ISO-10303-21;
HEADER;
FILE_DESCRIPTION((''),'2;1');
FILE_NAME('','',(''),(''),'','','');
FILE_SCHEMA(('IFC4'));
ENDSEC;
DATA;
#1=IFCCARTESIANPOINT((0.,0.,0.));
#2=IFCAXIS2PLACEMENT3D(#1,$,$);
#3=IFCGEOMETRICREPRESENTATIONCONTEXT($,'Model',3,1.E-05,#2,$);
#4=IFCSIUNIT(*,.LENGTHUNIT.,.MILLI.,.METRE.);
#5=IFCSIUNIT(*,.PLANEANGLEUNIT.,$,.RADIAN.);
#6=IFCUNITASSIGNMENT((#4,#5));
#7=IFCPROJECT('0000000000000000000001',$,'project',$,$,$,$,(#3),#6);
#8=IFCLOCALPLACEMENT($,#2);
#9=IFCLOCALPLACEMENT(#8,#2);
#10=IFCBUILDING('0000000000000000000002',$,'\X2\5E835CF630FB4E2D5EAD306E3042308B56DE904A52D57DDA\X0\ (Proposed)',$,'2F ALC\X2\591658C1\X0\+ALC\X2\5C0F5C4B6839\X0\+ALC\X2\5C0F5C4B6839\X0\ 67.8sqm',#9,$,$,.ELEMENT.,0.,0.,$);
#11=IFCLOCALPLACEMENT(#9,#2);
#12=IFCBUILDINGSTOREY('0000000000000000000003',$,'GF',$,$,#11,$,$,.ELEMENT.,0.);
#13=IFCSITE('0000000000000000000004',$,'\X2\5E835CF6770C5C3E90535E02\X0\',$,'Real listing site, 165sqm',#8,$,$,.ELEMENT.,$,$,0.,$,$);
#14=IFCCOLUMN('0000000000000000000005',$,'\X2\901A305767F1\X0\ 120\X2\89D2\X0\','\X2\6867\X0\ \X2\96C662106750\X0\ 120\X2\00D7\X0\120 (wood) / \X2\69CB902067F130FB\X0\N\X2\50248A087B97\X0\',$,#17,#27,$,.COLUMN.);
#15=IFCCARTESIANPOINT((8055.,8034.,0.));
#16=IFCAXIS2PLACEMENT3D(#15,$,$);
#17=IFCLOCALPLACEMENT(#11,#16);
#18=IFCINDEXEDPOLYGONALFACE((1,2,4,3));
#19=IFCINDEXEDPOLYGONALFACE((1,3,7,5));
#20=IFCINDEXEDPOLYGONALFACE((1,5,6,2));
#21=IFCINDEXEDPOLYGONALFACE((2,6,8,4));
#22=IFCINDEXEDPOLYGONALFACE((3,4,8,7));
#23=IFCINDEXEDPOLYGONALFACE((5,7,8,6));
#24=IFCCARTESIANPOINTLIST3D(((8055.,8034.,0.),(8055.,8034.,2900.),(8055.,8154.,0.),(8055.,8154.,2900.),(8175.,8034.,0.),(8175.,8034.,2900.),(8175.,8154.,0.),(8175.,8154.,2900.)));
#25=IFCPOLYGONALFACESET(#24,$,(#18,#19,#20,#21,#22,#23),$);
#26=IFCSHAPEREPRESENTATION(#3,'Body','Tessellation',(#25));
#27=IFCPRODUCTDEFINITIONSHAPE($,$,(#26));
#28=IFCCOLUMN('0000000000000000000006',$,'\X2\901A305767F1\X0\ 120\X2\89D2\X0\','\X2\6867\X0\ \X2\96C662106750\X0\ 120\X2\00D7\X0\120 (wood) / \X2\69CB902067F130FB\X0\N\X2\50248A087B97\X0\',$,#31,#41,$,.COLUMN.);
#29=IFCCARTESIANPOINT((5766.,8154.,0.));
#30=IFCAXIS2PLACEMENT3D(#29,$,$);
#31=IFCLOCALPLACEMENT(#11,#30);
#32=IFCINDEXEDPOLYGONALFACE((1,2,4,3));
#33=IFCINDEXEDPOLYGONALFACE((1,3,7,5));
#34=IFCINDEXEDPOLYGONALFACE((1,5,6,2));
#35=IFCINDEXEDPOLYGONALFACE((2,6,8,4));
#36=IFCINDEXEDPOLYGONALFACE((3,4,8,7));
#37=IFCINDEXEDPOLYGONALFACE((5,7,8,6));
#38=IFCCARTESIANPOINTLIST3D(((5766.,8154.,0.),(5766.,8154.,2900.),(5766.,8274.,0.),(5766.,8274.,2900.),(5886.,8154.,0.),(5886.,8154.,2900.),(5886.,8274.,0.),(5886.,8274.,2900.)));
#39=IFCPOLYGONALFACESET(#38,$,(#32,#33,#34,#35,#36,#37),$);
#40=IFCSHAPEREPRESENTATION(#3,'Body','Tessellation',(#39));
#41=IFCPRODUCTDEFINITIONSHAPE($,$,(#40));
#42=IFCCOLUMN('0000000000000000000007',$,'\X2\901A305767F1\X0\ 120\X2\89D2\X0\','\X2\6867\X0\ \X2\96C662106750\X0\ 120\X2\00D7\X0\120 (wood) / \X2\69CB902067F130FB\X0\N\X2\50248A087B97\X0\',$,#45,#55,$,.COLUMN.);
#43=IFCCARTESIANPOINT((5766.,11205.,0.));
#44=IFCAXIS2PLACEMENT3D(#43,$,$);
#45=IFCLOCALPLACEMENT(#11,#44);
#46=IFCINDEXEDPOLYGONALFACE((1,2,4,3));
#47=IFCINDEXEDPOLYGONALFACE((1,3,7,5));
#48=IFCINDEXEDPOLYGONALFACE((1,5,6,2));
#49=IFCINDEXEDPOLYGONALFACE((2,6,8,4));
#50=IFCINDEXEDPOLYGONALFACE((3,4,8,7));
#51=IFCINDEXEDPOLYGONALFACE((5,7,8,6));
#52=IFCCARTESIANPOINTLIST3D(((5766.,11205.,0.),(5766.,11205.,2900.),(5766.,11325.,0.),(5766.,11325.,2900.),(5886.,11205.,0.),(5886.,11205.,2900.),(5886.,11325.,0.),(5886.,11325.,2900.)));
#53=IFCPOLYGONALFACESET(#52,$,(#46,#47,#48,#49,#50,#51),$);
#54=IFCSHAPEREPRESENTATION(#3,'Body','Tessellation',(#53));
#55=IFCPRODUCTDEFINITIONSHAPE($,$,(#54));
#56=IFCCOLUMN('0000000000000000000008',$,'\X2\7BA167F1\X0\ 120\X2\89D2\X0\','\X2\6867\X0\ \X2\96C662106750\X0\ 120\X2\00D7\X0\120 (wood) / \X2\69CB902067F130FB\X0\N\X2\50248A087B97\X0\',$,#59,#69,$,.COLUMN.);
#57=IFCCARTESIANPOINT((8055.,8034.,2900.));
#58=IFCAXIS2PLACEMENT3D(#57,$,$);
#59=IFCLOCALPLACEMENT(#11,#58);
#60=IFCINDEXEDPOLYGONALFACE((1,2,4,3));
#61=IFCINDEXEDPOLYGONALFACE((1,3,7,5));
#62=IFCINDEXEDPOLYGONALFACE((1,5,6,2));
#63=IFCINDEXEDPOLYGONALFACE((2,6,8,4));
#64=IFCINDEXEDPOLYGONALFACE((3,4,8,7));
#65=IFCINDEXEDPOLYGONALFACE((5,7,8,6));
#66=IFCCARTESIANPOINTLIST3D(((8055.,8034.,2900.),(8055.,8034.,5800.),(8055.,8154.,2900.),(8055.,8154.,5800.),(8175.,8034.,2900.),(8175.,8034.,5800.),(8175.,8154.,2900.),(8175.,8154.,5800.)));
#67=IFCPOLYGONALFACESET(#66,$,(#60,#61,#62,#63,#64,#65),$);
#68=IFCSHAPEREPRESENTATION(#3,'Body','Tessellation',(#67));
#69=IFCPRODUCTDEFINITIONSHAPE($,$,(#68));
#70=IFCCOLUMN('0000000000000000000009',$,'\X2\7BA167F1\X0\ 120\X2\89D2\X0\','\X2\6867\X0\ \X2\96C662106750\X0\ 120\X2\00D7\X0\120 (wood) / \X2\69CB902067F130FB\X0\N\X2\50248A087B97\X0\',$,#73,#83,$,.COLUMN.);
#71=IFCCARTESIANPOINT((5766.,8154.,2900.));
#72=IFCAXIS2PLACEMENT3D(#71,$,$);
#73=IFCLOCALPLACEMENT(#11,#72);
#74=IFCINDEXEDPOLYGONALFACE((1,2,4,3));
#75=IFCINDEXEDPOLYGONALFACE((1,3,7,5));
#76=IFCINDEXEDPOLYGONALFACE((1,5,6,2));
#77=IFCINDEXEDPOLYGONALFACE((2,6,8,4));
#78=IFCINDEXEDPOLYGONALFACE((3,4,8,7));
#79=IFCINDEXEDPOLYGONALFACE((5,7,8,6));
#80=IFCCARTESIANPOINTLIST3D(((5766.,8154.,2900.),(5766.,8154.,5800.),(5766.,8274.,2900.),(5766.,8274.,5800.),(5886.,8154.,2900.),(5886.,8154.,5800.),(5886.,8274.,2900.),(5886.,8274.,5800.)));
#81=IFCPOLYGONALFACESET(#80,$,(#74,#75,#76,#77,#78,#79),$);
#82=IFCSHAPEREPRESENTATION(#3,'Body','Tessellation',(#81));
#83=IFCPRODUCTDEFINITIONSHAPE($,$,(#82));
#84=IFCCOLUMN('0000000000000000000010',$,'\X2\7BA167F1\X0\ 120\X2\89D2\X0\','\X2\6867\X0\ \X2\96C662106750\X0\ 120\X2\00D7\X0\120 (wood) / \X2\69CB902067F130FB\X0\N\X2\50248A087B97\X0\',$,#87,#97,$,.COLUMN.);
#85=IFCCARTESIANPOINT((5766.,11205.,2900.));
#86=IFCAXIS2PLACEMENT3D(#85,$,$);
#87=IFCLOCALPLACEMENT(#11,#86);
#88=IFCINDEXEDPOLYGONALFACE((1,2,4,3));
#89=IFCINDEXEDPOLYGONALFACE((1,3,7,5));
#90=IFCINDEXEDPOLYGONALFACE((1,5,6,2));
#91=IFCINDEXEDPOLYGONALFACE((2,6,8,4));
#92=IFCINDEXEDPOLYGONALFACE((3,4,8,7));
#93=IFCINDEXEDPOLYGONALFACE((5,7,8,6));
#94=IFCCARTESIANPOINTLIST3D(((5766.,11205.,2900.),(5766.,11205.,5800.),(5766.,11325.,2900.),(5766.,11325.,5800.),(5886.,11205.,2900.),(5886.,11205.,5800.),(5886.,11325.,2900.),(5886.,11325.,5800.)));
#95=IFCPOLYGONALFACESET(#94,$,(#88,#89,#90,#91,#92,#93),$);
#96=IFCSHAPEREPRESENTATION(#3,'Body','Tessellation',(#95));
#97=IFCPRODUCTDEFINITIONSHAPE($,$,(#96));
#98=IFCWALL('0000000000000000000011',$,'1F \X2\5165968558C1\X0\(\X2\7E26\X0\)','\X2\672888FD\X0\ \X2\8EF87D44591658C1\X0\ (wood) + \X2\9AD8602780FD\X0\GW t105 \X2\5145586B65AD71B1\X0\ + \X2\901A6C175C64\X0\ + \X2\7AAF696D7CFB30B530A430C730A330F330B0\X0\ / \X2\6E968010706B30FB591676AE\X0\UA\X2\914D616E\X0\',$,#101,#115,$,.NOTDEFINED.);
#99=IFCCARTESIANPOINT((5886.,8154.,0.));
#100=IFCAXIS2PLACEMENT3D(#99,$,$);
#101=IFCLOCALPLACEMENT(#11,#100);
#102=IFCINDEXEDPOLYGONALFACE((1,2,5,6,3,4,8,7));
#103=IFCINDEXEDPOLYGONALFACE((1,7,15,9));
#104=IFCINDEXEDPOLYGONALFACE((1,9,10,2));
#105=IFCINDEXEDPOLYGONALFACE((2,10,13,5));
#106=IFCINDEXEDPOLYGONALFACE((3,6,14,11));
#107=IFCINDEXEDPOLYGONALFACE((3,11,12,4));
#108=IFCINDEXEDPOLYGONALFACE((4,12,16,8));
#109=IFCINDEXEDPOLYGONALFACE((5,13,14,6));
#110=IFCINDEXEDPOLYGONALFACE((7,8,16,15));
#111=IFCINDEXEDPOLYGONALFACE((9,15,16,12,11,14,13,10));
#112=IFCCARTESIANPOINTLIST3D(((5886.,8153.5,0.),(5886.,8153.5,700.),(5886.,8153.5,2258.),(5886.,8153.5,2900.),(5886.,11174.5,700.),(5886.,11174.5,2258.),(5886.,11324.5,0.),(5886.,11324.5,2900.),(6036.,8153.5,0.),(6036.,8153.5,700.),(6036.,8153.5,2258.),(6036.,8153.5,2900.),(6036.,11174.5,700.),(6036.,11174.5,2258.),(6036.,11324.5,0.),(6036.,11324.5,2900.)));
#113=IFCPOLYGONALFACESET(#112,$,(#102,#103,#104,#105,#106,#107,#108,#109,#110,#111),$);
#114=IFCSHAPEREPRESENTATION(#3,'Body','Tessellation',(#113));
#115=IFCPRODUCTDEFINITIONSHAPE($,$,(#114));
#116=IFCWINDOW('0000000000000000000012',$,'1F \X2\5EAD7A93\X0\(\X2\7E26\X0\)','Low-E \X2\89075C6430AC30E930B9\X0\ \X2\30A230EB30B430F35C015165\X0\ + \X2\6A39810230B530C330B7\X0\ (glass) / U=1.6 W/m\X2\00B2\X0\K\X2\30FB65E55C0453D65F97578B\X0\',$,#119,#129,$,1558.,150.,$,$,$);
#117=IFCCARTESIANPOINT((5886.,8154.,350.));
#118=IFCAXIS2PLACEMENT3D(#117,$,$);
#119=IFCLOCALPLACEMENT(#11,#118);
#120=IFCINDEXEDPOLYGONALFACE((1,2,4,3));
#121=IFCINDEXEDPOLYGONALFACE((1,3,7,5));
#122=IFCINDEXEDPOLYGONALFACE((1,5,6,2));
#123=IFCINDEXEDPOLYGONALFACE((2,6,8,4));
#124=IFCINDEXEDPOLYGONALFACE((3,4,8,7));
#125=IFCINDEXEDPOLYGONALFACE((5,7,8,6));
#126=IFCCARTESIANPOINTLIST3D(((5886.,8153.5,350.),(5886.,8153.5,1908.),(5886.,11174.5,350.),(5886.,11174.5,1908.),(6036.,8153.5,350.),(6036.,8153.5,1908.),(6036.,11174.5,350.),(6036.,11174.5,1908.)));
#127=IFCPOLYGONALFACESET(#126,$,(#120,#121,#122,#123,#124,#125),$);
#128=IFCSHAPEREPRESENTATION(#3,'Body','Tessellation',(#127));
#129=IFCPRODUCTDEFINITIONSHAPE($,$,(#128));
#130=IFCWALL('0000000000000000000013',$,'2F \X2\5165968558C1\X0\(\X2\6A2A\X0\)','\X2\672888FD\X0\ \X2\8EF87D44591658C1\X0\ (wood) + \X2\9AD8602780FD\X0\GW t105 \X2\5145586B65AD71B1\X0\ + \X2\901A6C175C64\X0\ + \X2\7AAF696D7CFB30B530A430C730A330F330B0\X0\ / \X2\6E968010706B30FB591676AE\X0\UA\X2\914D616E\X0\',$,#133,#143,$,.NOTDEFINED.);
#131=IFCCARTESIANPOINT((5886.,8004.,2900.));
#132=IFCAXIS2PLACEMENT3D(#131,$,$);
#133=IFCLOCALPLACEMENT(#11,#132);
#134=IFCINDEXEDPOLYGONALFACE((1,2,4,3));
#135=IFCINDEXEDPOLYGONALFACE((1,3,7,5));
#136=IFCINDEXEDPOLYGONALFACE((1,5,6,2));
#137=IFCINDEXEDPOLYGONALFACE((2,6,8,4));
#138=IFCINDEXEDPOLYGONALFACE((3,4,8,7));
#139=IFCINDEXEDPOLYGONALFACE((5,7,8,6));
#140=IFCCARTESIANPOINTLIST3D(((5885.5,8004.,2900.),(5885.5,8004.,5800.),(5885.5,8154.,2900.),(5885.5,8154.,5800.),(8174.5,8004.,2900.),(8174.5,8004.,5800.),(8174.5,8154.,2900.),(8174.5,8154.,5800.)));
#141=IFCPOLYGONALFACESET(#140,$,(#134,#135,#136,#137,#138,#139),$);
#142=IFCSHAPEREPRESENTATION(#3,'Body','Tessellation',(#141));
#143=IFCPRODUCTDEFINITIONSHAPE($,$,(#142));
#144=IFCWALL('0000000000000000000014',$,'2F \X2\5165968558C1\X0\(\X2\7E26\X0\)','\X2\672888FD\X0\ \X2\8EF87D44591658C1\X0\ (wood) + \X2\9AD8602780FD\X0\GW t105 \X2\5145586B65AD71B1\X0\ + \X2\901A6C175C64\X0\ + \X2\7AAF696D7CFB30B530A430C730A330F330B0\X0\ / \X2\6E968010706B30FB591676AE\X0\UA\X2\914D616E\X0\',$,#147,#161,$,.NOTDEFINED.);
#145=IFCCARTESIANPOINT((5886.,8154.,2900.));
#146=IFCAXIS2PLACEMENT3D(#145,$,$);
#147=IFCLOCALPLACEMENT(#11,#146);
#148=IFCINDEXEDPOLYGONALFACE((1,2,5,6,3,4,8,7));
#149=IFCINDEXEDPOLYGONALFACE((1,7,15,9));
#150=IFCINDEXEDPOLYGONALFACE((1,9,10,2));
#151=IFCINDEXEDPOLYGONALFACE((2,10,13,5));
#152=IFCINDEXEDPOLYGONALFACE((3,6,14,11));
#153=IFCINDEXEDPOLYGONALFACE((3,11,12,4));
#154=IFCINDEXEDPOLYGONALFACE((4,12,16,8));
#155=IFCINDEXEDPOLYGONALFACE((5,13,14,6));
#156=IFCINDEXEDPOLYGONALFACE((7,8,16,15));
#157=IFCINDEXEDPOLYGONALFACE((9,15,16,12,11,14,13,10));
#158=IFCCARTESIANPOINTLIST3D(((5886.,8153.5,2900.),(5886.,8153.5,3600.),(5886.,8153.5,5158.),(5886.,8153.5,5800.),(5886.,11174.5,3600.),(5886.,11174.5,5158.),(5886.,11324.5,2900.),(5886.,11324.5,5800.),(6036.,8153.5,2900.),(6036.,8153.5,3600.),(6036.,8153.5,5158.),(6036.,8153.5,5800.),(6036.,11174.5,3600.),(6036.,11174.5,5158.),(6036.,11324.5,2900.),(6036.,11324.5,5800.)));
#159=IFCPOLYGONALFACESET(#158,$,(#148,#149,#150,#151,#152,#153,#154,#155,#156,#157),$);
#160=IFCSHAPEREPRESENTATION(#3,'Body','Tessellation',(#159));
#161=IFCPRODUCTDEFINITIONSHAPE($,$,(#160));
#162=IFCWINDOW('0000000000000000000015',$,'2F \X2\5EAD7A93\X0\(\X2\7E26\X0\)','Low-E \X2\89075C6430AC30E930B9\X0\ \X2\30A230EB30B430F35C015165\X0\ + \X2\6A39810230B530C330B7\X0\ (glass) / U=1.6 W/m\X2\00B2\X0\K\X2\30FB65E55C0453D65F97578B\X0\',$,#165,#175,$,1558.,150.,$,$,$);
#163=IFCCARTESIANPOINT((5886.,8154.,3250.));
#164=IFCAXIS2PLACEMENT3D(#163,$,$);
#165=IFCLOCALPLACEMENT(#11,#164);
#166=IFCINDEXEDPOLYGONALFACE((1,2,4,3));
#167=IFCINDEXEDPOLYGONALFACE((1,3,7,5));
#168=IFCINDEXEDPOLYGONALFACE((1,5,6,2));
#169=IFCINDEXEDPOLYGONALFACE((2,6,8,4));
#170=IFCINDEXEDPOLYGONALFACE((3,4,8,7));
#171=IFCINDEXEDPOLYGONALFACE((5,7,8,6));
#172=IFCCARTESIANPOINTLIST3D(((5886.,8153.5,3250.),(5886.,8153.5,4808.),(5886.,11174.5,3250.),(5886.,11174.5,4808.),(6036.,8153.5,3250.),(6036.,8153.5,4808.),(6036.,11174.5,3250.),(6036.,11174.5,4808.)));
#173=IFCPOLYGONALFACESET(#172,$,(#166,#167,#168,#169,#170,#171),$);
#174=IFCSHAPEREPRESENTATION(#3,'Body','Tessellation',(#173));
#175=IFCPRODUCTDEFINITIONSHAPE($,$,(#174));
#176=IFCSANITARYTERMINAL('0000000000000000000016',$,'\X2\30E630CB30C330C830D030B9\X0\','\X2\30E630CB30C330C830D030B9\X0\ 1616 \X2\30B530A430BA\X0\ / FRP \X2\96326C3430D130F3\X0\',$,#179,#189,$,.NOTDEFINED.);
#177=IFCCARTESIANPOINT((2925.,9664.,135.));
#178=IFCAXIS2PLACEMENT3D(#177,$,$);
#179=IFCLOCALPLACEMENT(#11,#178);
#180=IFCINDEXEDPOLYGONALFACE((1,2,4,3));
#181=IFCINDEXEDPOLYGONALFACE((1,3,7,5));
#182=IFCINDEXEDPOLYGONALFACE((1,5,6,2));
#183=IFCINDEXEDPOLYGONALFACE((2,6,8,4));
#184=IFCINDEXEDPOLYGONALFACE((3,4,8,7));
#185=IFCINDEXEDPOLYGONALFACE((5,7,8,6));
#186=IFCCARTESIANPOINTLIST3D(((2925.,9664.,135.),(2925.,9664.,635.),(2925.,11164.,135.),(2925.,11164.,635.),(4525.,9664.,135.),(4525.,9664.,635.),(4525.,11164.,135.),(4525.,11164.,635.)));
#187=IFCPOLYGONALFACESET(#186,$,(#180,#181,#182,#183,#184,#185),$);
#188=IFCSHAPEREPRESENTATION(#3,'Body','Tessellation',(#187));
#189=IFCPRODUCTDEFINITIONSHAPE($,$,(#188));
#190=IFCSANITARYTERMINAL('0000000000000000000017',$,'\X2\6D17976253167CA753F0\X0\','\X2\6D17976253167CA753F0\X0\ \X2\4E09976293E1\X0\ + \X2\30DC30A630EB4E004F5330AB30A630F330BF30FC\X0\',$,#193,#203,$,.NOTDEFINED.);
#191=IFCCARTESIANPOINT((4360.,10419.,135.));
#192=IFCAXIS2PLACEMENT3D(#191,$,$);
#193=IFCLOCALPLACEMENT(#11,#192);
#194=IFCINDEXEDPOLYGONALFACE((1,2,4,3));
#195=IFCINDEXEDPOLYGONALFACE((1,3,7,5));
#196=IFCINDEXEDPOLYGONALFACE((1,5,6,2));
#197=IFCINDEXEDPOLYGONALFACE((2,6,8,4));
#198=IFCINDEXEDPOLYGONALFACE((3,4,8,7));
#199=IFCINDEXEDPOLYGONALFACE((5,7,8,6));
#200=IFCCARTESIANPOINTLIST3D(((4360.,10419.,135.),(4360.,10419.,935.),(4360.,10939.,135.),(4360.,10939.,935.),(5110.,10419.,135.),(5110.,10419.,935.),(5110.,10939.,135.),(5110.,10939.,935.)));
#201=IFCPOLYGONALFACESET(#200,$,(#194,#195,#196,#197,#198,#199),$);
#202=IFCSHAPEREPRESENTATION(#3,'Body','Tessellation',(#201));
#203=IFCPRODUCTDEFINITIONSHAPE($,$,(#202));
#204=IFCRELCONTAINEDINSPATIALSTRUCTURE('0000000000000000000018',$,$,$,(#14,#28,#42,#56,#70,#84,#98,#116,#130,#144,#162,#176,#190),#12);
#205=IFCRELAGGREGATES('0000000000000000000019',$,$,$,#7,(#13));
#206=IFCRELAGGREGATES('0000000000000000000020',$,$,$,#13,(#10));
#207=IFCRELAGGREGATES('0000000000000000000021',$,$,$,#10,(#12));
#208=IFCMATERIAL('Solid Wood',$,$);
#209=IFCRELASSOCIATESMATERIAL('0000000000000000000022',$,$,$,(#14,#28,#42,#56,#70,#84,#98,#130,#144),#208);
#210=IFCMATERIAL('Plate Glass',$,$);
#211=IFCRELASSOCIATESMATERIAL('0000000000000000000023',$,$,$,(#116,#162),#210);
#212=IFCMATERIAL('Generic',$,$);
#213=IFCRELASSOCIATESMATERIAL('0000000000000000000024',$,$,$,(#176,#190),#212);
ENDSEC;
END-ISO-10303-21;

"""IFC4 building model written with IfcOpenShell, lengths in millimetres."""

from ifc_helpers import new_model, si_unit, frame, frame_2d, origin, place, context, project, spatial, rectangle, extrude, material, element, fill, save


model = new_model("IFC4")

# Units and contexts
model_context = context("Model", 3, precision=1e-05, world=origin())
ifc_project = project(units=[si_unit("LENGTHUNIT", "METRE", prefix="MILLI"), si_unit("PLANEANGLEUNIT", "RADIAN")], contexts=[model_context])

# Site, building, storey
site_placement = place(None, origin())
site = spatial("IfcSite", under=ifc_project, at=site_placement, Name="広島県尾道市", ObjectType="Real listing site, 165sqm", CompositionType="ELEMENT", RefElevation=0.0)
building_placement = place(site_placement, origin())
building = spatial("IfcBuilding", under=site, at=building_placement, Name="広島・中庭のある回遊動線 (Proposed)", ObjectType="2F ALC外壁+ALC小屋根+ALC小屋根 67.8sqm", CompositionType="ELEMENT", ElevationOfRefHeight=0.0, ElevationOfTerrain=0.0)
storey_placement = place(building_placement, origin())
storey = spatial("IfcBuildingStorey", under=building, at=storey_placement, Name="GF", CompositionType="ELEMENT", Elevation=0.0)

# Columns
ifc_material_1 = material(Name="Solid Wood")
column_1_placement = place(storey_placement, frame((8055.0, 8034.0, 0.0)))
element("IfcColumn", 1, at=column_1_placement, inside=storey, material=ifc_material_1, Name="通し柱 120角", Description="桧 集成材 120×120 (wood) / 構造柱・N値計算", PredefinedType="COLUMN", context=model_context, shape_type="SweptSolid", body=[
    extrude(rectangle(XDim=120.0, YDim=120.0, at=frame_2d((60.0, 60.0))), frame((8055.0, 8034.0, 0.0)), (0.0, 0.0, 1.0), 2900.0),
])
column_2_placement = place(storey_placement, frame((5766.0, 8154.0, 0.0)))
element("IfcColumn", 2, at=column_2_placement, inside=storey, material=ifc_material_1, Name="通し柱 120角", Description="桧 集成材 120×120 (wood) / 構造柱・N値計算", PredefinedType="COLUMN", context=model_context, shape_type="SweptSolid", body=[
    extrude(rectangle(XDim=120.0, YDim=120.0, at=frame_2d((60.0, 60.0))), frame((5766.0, 8154.0, 0.0)), (0.0, 0.0, 1.0), 2900.0),
])
column_3_placement = place(storey_placement, frame((5766.0, 11205.0, 0.0)))
element("IfcColumn", 3, at=column_3_placement, inside=storey, material=ifc_material_1, Name="通し柱 120角", Description="桧 集成材 120×120 (wood) / 構造柱・N値計算", PredefinedType="COLUMN", context=model_context, shape_type="SweptSolid", body=[
    extrude(rectangle(XDim=120.0, YDim=120.0, at=frame_2d((60.0, 60.0))), frame((5766.0, 11205.0, 0.0)), (0.0, 0.0, 1.0), 2900.0),
])
column_4_placement = place(storey_placement, frame((8055.0, 8034.0, 2900.0)))
element("IfcColumn", 4, at=column_4_placement, inside=storey, material=ifc_material_1, Name="管柱 120角", Description="桧 集成材 120×120 (wood) / 構造柱・N値計算", PredefinedType="COLUMN", context=model_context, shape_type="SweptSolid", body=[
    extrude(rectangle(XDim=120.0, YDim=120.0, at=frame_2d((60.0, 60.0))), frame((8055.0, 8034.0, 2900.0)), (0.0, 0.0, 1.0), 2900.0),
])
column_5_placement = place(storey_placement, frame((5766.0, 8154.0, 2900.0)))
element("IfcColumn", 5, at=column_5_placement, inside=storey, material=ifc_material_1, Name="管柱 120角", Description="桧 集成材 120×120 (wood) / 構造柱・N値計算", PredefinedType="COLUMN", context=model_context, shape_type="SweptSolid", body=[
    extrude(rectangle(XDim=120.0, YDim=120.0, at=frame_2d((60.0, 60.0))), frame((5766.0, 8154.0, 2900.0)), (0.0, 0.0, 1.0), 2900.0),
])
column_6_placement = place(storey_placement, frame((5766.0, 11205.0, 2900.0)))
element("IfcColumn", 6, at=column_6_placement, inside=storey, material=ifc_material_1, Name="管柱 120角", Description="桧 集成材 120×120 (wood) / 構造柱・N値計算", PredefinedType="COLUMN", context=model_context, shape_type="SweptSolid", body=[
    extrude(rectangle(XDim=120.0, YDim=120.0, at=frame_2d((60.0, 60.0))), frame((5766.0, 11205.0, 2900.0)), (0.0, 0.0, 1.0), 2900.0),
])

# Wall, opening, window
wall_1_placement = place(storey_placement, frame((5886.0, 8154.0, 0.0)))
wall_1 = element("IfcWall", 7, at=wall_1_placement, inside=storey, material=ifc_material_1, Name="1F 入隅壁(縦)", Description="木製 軸組外壁 (wood) + 高性能GW t105 充填断熱 + 通気層 + 窯業系サイディング / 準耐火・外皮UA配慮", PredefinedType="NOTDEFINED", context=model_context, shape_type="SweptSolid", body=[
    extrude(rectangle(XDim=150.0, YDim=3171.0, at=frame_2d((75.0, 1585.0))), frame((5886.0, 8154.0, 0.0)), (0.0, 0.0, 1.0), 2900.0),
])
opening_1_placement = place(storey_placement, frame((5886.0, 8154.0, 350.0)))
opening_1 = element("IfcOpeningElement", 8, at=opening_1_placement, cuts=wall_1, PredefinedType="NOTDEFINED", context=model_context, shape_type="SweptSolid", body=[
    extrude(rectangle(XDim=150.0, YDim=3021.0, at=frame_2d((75.0, 1510.0))), frame((5886.0, 8154.0, 350.0)), (0.0, 0.0, 1.0), 1558.0),
])
ifc_material_2 = material(Name="Plate Glass")
window_1_placement = place(storey_placement, frame((5886.0, 8154.0, 350.0)))
window_1 = element("IfcWindow", 9, at=window_1_placement, inside=storey, material=ifc_material_2, Name="1F 庭窓(縦)", Description="Low-E 複層ガラス アルゴン封入 + 樹脂サッシ (glass) / U=1.6 W/m²K・日射取得型", OverallHeight=1558.0, OverallWidth=150.0, context=model_context, shape_type="SweptSolid", body=[
    extrude(rectangle(XDim=150.0, YDim=3021.0, at=frame_2d((75.0, 1510.0))), frame((5886.0, 8154.0, 350.0)), (0.0, 0.0, 1.0), 1558.0),
])
fill(opening_1, window_1)

# Wall
wall_2_placement = place(storey_placement, frame((5886.0, 8004.0, 2900.0)))
element("IfcWall", 10, at=wall_2_placement, inside=storey, material=ifc_material_1, Name="2F 入隅壁(横)", Description="木製 軸組外壁 (wood) + 高性能GW t105 充填断熱 + 通気層 + 窯業系サイディング / 準耐火・外皮UA配慮", PredefinedType="NOTDEFINED", context=model_context, shape_type="SweptSolid", body=[
    extrude(rectangle(XDim=2289.0, YDim=150.0, at=frame_2d((1144.0, 75.0))), frame((5886.0, 8004.0, 2900.0)), (0.0, 0.0, 1.0), 2900.0),
])

# Wall, opening, window
wall_3_placement = place(storey_placement, frame((5886.0, 8154.0, 2900.0)))
wall_3 = element("IfcWall", 11, at=wall_3_placement, inside=storey, material=ifc_material_1, Name="2F 入隅壁(縦)", Description="木製 軸組外壁 (wood) + 高性能GW t105 充填断熱 + 通気層 + 窯業系サイディング / 準耐火・外皮UA配慮", PredefinedType="NOTDEFINED", context=model_context, shape_type="SweptSolid", body=[
    extrude(rectangle(XDim=150.0, YDim=3171.0, at=frame_2d((75.0, 1585.0))), frame((5886.0, 8154.0, 2900.0)), (0.0, 0.0, 1.0), 2900.0),
])
opening_2_placement = place(storey_placement, frame((5886.0, 8154.0, 3250.0)))
opening_2 = element("IfcOpeningElement", 12, at=opening_2_placement, cuts=wall_3, PredefinedType="NOTDEFINED", context=model_context, shape_type="SweptSolid", body=[
    extrude(rectangle(XDim=150.0, YDim=3021.0, at=frame_2d((75.0, 1510.0))), frame((5886.0, 8154.0, 3250.0)), (0.0, 0.0, 1.0), 1558.0),
])
window_2_placement = place(storey_placement, frame((5886.0, 8154.0, 3250.0)))
window_2 = element("IfcWindow", 13, at=window_2_placement, inside=storey, material=ifc_material_2, Name="2F 庭窓(縦)", Description="Low-E 複層ガラス アルゴン封入 + 樹脂サッシ (glass) / U=1.6 W/m²K・日射取得型", OverallHeight=1558.0, OverallWidth=150.0, context=model_context, shape_type="SweptSolid", body=[
    extrude(rectangle(XDim=150.0, YDim=3021.0, at=frame_2d((75.0, 1510.0))), frame((5886.0, 8154.0, 3250.0)), (0.0, 0.0, 1.0), 1558.0),
])
fill(opening_2, window_2)

# Sanitary terminals
ifc_material_3 = material(Name="Generic")
sanitary_terminal_1_placement = place(storey_placement, frame((2925.0, 9664.0, 135.0)))
element("IfcSanitaryTerminal", 14, at=sanitary_terminal_1_placement, inside=storey, material=ifc_material_3, Name="ユニットバス", Description="ユニットバス 1616 サイズ / FRP 防水パン", PredefinedType="NOTDEFINED", context=model_context, shape_type="SweptSolid", body=[
    extrude(rectangle(XDim=1600.0, YDim=1500.0, at=frame_2d((800.0, 750.0))), frame((2925.0, 9664.0, 135.0)), (0.0, 0.0, 1.0), 500.0),
])
sanitary_terminal_2_placement = place(storey_placement, frame((4360.0, 10419.0, 135.0)))
element("IfcSanitaryTerminal", 15, at=sanitary_terminal_2_placement, inside=storey, material=ifc_material_3, Name="洗面化粧台", Description="洗面化粧台 三面鏡 + ボウル一体カウンター", PredefinedType="NOTDEFINED", context=model_context, shape_type="SweptSolid", body=[
    extrude(rectangle(XDim=750.0, YDim=520.0, at=frame_2d((375.0, 260.0))), frame((4360.0, 10419.0, 135.0)), (0.0, 0.0, 1.0), 800.0),
])

save(model, "model.ifc")
